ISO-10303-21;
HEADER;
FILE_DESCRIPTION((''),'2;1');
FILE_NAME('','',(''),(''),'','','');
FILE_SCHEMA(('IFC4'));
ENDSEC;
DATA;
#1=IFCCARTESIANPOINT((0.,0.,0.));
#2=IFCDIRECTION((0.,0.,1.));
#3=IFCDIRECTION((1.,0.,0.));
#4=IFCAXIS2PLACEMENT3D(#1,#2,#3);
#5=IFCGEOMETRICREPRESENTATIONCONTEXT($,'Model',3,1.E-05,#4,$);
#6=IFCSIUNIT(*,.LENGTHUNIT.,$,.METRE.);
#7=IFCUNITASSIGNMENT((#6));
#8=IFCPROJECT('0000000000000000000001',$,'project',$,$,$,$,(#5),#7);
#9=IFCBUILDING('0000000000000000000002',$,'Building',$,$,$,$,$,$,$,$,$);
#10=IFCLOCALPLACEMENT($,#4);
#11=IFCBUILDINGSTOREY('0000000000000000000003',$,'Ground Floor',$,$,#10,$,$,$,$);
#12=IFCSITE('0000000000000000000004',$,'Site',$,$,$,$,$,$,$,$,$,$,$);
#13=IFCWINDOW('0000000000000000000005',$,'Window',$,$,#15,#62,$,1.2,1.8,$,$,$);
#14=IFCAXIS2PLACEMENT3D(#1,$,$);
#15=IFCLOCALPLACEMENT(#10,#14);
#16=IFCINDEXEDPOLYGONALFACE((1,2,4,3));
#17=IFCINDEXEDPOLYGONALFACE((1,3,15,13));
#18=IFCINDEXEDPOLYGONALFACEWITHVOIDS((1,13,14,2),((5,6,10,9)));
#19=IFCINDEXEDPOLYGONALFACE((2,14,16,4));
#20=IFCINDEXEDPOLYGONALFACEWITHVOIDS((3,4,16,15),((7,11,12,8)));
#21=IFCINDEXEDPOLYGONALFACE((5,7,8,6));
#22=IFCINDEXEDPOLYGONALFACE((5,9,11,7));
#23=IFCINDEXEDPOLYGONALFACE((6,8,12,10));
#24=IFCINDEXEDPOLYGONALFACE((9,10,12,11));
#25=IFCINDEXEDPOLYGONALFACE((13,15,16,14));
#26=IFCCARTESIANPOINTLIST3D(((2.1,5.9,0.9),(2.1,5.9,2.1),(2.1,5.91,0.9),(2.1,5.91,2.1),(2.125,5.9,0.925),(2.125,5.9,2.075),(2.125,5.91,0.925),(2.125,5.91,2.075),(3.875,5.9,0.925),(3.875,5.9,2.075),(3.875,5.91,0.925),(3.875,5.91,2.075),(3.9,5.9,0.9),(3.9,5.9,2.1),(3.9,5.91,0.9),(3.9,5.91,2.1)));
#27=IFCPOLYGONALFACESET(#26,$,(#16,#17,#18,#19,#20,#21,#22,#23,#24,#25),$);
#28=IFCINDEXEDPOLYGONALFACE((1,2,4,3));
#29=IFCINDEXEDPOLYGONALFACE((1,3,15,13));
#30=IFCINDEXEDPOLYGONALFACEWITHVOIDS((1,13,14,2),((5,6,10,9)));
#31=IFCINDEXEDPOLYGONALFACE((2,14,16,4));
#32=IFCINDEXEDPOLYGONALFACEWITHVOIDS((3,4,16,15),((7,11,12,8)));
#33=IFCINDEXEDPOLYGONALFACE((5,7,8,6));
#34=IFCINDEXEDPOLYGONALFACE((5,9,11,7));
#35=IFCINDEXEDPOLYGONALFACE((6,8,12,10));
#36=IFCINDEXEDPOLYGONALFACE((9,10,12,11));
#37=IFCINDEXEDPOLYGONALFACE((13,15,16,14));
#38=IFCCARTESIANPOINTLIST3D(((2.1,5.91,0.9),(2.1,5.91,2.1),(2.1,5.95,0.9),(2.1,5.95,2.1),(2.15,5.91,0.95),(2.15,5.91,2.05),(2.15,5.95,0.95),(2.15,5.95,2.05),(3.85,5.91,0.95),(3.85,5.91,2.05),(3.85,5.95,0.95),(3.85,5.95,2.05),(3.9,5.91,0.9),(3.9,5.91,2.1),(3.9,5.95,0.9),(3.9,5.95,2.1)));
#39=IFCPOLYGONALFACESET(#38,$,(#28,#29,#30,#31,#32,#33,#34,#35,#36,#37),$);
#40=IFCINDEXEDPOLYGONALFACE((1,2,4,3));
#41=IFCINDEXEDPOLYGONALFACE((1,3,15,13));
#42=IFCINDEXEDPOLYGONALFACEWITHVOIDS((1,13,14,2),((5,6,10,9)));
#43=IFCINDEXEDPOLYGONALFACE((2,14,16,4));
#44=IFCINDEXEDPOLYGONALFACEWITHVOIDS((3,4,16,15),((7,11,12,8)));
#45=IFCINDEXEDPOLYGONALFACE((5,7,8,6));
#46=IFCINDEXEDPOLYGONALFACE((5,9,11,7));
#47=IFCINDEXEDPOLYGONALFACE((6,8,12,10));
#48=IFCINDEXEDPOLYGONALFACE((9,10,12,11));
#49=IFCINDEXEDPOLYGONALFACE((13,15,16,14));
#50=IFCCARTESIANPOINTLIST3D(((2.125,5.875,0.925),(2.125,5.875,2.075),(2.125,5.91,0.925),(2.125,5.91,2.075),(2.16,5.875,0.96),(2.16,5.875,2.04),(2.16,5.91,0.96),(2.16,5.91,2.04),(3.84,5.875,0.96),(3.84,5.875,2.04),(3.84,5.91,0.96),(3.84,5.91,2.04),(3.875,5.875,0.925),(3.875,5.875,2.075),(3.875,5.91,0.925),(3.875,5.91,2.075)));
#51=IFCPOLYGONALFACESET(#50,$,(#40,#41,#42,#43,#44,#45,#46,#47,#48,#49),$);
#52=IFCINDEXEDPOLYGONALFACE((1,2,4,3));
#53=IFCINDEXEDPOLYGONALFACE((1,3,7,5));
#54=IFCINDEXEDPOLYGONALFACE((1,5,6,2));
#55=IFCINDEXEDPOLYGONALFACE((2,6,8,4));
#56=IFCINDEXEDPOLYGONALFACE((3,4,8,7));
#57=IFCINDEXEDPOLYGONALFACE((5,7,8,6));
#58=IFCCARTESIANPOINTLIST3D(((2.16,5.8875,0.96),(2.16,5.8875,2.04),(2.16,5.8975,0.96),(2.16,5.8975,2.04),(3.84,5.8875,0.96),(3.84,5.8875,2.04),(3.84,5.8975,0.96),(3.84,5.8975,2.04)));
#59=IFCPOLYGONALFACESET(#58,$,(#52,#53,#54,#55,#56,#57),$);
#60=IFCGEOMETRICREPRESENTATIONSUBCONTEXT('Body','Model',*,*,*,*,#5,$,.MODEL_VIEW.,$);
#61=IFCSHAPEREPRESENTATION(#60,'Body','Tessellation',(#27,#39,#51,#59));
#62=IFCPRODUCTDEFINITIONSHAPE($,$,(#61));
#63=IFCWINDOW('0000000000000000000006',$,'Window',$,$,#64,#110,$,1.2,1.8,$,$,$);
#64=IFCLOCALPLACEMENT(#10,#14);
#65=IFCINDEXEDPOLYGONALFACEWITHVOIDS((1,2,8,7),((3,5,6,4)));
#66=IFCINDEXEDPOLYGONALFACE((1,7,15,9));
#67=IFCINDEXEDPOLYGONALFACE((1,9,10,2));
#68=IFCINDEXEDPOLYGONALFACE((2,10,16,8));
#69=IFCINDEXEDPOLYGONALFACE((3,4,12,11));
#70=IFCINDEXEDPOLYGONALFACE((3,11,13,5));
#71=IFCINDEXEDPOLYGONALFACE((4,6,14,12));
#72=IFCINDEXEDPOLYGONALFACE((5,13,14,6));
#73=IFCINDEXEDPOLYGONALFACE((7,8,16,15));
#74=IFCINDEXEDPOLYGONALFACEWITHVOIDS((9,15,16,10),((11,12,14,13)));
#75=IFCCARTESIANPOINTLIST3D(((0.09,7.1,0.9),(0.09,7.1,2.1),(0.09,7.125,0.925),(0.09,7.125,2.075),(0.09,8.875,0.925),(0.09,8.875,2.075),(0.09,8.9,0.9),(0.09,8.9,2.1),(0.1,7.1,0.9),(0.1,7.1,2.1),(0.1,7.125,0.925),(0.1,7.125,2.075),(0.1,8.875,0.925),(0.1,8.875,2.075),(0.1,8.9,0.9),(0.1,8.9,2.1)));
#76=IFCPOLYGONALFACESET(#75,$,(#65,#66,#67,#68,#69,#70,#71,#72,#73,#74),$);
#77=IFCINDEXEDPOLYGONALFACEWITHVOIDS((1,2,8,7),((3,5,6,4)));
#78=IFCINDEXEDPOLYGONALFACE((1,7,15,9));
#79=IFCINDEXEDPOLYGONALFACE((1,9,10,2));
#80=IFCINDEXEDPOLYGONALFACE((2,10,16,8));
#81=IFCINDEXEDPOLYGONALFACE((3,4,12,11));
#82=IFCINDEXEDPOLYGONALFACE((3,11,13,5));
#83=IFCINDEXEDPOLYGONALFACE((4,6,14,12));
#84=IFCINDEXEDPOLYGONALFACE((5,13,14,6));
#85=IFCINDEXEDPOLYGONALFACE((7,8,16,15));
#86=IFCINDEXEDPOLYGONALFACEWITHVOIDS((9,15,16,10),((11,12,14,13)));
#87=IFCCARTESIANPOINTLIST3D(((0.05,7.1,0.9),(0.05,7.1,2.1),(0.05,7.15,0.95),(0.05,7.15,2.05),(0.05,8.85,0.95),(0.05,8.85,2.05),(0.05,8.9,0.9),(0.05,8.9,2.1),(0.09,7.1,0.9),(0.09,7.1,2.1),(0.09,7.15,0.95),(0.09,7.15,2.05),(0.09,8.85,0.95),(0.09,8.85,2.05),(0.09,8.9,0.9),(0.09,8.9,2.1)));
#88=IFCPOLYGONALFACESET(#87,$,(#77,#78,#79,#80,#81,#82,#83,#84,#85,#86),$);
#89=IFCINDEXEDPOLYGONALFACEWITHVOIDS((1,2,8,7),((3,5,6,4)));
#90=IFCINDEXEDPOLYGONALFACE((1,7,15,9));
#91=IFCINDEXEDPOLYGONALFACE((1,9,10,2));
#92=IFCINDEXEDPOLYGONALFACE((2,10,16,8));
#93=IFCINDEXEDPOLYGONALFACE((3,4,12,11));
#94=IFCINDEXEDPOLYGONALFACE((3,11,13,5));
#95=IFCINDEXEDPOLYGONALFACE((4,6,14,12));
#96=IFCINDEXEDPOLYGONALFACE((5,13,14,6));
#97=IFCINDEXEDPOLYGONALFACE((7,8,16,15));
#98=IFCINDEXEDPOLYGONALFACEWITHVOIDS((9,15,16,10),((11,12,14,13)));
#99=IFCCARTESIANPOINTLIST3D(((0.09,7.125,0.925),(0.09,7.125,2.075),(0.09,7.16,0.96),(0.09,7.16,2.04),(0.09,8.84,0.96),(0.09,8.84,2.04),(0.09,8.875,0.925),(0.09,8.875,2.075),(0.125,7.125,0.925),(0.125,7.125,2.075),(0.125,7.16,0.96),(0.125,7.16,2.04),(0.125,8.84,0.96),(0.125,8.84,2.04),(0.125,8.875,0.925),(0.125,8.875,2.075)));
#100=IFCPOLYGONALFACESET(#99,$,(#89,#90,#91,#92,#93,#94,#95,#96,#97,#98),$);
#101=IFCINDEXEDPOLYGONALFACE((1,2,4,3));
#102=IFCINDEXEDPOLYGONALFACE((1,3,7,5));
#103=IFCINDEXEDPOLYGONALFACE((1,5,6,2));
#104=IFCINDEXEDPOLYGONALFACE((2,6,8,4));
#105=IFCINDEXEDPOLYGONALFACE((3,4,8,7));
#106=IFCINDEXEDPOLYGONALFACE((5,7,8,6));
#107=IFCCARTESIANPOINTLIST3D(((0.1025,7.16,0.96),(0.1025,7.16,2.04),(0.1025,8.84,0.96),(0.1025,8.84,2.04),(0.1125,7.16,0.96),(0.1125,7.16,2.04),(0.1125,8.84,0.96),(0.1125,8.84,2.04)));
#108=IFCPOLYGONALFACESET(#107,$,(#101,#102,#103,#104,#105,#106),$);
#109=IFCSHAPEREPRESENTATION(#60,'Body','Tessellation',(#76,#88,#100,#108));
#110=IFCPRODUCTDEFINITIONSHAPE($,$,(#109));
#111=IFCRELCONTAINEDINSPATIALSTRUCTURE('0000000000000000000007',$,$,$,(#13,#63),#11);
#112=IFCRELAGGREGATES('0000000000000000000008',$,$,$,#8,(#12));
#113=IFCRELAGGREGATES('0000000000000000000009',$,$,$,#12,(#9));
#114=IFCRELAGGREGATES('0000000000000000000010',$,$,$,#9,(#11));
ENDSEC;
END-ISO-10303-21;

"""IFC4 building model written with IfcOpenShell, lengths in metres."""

from ifc_helpers import new_model, si_unit, frame, origin_with_axes, place, context, subcontext, project, spatial, line, indexed_curve, outline, extrude, element, save


model = new_model("IFC4")

# Units and contexts
model_context = context("Model", 3, precision=1e-05, world=origin_with_axes())
body_context = subcontext(model_context, "Body", "Model", "MODEL_VIEW")
ifc_project = project(units=[si_unit("LENGTHUNIT", "METRE")], contexts=[model_context])

# Site, building, storey
site = spatial("IfcSite", under=ifc_project, Name="Site")
building = spatial("IfcBuilding", under=site, Name="Building")
storey_placement = place(None, origin_with_axes())
storey = spatial("IfcBuildingStorey", under=building, at=storey_placement, Name="Ground Floor")

# Windows
for number, where, z_axis, x_axis, name in (
    (1, (3.9, 6.0, 0.9), (0.0, 0.0, 1.0), (-1.0, 0.0, 0.0), "Window"),
    (2, (0.0, 8.9, 0.9), (0.0, 0.0, 1.0), (0.0, -1.0, 0.0), "Window"),
):
    element("IfcWindow", number, at=place(storey_placement, frame(where, z_axis=z_axis, x_axis=x_axis)), inside=storey, Name=name, OverallHeight=1.2, OverallWidth=1.8, context=body_context, shape_type="SweptSolid", body=[
        extrude(outline(indexed_curve([(0.0, 0.0), (1.8, 0.0), (1.8, 1.2), (0.0, 1.2)], segments=[line(1, 2, 3, 4, 1)]), holes=[indexed_curve([(0.025, 0.025), (1.775, 0.025), (1.775, 1.175), (0.025, 1.175)], segments=[line(1, 2, 3, 4, 1)])]), frame((0.0, 0.09, 0.0), z_axis=(0.0, -1.0, 0.0), x_axis=(1.0, 0.0, 0.0)), (0.0, 0.0, -1.0), 0.01),
        extrude(outline(indexed_curve([(0.0, 0.0), (1.8, 0.0), (1.8, 1.2), (0.0, 1.2)], segments=[line(1, 2, 3, 4, 1)]), holes=[indexed_curve([(0.05, 0.05), (1.75, 0.05), (1.75, 1.15), (0.05, 1.15)], segments=[line(1, 2, 3, 4, 1)])]), frame((0.0, 0.05, 0.0), z_axis=(0.0, -1.0, 0.0), x_axis=(1.0, 0.0, 0.0)), (0.0, 0.0, -1.0), 0.04),
        extrude(outline(indexed_curve([(0.0, 0.0), (1.75, 0.0), (1.75, 1.15), (0.0, 1.15)], segments=[line(1, 2, 3, 4, 1)]), holes=[indexed_curve([(0.035, 0.035), (1.715, 0.035), (1.715, 1.115), (0.035, 1.115)], segments=[line(1, 2, 3, 4, 1)])]), frame((0.025, 0.09, 0.025), z_axis=(0.0, -1.0, 0.0), x_axis=(1.0, 0.0, 0.0)), (0.0, 0.0, -1.0), 0.035),
        extrude(outline(indexed_curve([(0.035, 0.035), (1.715, 0.035), (1.715, 1.115), (0.035, 1.115)], segments=[line(1, 2, 3, 4, 1)])), frame((0.025, 0.1025, 0.025), z_axis=(0.0, -1.0, 0.0), x_axis=(1.0, 0.0, 0.0)), (0.0, 0.0, -1.0), 0.01),
    ])

save(model, "model.ifc")
